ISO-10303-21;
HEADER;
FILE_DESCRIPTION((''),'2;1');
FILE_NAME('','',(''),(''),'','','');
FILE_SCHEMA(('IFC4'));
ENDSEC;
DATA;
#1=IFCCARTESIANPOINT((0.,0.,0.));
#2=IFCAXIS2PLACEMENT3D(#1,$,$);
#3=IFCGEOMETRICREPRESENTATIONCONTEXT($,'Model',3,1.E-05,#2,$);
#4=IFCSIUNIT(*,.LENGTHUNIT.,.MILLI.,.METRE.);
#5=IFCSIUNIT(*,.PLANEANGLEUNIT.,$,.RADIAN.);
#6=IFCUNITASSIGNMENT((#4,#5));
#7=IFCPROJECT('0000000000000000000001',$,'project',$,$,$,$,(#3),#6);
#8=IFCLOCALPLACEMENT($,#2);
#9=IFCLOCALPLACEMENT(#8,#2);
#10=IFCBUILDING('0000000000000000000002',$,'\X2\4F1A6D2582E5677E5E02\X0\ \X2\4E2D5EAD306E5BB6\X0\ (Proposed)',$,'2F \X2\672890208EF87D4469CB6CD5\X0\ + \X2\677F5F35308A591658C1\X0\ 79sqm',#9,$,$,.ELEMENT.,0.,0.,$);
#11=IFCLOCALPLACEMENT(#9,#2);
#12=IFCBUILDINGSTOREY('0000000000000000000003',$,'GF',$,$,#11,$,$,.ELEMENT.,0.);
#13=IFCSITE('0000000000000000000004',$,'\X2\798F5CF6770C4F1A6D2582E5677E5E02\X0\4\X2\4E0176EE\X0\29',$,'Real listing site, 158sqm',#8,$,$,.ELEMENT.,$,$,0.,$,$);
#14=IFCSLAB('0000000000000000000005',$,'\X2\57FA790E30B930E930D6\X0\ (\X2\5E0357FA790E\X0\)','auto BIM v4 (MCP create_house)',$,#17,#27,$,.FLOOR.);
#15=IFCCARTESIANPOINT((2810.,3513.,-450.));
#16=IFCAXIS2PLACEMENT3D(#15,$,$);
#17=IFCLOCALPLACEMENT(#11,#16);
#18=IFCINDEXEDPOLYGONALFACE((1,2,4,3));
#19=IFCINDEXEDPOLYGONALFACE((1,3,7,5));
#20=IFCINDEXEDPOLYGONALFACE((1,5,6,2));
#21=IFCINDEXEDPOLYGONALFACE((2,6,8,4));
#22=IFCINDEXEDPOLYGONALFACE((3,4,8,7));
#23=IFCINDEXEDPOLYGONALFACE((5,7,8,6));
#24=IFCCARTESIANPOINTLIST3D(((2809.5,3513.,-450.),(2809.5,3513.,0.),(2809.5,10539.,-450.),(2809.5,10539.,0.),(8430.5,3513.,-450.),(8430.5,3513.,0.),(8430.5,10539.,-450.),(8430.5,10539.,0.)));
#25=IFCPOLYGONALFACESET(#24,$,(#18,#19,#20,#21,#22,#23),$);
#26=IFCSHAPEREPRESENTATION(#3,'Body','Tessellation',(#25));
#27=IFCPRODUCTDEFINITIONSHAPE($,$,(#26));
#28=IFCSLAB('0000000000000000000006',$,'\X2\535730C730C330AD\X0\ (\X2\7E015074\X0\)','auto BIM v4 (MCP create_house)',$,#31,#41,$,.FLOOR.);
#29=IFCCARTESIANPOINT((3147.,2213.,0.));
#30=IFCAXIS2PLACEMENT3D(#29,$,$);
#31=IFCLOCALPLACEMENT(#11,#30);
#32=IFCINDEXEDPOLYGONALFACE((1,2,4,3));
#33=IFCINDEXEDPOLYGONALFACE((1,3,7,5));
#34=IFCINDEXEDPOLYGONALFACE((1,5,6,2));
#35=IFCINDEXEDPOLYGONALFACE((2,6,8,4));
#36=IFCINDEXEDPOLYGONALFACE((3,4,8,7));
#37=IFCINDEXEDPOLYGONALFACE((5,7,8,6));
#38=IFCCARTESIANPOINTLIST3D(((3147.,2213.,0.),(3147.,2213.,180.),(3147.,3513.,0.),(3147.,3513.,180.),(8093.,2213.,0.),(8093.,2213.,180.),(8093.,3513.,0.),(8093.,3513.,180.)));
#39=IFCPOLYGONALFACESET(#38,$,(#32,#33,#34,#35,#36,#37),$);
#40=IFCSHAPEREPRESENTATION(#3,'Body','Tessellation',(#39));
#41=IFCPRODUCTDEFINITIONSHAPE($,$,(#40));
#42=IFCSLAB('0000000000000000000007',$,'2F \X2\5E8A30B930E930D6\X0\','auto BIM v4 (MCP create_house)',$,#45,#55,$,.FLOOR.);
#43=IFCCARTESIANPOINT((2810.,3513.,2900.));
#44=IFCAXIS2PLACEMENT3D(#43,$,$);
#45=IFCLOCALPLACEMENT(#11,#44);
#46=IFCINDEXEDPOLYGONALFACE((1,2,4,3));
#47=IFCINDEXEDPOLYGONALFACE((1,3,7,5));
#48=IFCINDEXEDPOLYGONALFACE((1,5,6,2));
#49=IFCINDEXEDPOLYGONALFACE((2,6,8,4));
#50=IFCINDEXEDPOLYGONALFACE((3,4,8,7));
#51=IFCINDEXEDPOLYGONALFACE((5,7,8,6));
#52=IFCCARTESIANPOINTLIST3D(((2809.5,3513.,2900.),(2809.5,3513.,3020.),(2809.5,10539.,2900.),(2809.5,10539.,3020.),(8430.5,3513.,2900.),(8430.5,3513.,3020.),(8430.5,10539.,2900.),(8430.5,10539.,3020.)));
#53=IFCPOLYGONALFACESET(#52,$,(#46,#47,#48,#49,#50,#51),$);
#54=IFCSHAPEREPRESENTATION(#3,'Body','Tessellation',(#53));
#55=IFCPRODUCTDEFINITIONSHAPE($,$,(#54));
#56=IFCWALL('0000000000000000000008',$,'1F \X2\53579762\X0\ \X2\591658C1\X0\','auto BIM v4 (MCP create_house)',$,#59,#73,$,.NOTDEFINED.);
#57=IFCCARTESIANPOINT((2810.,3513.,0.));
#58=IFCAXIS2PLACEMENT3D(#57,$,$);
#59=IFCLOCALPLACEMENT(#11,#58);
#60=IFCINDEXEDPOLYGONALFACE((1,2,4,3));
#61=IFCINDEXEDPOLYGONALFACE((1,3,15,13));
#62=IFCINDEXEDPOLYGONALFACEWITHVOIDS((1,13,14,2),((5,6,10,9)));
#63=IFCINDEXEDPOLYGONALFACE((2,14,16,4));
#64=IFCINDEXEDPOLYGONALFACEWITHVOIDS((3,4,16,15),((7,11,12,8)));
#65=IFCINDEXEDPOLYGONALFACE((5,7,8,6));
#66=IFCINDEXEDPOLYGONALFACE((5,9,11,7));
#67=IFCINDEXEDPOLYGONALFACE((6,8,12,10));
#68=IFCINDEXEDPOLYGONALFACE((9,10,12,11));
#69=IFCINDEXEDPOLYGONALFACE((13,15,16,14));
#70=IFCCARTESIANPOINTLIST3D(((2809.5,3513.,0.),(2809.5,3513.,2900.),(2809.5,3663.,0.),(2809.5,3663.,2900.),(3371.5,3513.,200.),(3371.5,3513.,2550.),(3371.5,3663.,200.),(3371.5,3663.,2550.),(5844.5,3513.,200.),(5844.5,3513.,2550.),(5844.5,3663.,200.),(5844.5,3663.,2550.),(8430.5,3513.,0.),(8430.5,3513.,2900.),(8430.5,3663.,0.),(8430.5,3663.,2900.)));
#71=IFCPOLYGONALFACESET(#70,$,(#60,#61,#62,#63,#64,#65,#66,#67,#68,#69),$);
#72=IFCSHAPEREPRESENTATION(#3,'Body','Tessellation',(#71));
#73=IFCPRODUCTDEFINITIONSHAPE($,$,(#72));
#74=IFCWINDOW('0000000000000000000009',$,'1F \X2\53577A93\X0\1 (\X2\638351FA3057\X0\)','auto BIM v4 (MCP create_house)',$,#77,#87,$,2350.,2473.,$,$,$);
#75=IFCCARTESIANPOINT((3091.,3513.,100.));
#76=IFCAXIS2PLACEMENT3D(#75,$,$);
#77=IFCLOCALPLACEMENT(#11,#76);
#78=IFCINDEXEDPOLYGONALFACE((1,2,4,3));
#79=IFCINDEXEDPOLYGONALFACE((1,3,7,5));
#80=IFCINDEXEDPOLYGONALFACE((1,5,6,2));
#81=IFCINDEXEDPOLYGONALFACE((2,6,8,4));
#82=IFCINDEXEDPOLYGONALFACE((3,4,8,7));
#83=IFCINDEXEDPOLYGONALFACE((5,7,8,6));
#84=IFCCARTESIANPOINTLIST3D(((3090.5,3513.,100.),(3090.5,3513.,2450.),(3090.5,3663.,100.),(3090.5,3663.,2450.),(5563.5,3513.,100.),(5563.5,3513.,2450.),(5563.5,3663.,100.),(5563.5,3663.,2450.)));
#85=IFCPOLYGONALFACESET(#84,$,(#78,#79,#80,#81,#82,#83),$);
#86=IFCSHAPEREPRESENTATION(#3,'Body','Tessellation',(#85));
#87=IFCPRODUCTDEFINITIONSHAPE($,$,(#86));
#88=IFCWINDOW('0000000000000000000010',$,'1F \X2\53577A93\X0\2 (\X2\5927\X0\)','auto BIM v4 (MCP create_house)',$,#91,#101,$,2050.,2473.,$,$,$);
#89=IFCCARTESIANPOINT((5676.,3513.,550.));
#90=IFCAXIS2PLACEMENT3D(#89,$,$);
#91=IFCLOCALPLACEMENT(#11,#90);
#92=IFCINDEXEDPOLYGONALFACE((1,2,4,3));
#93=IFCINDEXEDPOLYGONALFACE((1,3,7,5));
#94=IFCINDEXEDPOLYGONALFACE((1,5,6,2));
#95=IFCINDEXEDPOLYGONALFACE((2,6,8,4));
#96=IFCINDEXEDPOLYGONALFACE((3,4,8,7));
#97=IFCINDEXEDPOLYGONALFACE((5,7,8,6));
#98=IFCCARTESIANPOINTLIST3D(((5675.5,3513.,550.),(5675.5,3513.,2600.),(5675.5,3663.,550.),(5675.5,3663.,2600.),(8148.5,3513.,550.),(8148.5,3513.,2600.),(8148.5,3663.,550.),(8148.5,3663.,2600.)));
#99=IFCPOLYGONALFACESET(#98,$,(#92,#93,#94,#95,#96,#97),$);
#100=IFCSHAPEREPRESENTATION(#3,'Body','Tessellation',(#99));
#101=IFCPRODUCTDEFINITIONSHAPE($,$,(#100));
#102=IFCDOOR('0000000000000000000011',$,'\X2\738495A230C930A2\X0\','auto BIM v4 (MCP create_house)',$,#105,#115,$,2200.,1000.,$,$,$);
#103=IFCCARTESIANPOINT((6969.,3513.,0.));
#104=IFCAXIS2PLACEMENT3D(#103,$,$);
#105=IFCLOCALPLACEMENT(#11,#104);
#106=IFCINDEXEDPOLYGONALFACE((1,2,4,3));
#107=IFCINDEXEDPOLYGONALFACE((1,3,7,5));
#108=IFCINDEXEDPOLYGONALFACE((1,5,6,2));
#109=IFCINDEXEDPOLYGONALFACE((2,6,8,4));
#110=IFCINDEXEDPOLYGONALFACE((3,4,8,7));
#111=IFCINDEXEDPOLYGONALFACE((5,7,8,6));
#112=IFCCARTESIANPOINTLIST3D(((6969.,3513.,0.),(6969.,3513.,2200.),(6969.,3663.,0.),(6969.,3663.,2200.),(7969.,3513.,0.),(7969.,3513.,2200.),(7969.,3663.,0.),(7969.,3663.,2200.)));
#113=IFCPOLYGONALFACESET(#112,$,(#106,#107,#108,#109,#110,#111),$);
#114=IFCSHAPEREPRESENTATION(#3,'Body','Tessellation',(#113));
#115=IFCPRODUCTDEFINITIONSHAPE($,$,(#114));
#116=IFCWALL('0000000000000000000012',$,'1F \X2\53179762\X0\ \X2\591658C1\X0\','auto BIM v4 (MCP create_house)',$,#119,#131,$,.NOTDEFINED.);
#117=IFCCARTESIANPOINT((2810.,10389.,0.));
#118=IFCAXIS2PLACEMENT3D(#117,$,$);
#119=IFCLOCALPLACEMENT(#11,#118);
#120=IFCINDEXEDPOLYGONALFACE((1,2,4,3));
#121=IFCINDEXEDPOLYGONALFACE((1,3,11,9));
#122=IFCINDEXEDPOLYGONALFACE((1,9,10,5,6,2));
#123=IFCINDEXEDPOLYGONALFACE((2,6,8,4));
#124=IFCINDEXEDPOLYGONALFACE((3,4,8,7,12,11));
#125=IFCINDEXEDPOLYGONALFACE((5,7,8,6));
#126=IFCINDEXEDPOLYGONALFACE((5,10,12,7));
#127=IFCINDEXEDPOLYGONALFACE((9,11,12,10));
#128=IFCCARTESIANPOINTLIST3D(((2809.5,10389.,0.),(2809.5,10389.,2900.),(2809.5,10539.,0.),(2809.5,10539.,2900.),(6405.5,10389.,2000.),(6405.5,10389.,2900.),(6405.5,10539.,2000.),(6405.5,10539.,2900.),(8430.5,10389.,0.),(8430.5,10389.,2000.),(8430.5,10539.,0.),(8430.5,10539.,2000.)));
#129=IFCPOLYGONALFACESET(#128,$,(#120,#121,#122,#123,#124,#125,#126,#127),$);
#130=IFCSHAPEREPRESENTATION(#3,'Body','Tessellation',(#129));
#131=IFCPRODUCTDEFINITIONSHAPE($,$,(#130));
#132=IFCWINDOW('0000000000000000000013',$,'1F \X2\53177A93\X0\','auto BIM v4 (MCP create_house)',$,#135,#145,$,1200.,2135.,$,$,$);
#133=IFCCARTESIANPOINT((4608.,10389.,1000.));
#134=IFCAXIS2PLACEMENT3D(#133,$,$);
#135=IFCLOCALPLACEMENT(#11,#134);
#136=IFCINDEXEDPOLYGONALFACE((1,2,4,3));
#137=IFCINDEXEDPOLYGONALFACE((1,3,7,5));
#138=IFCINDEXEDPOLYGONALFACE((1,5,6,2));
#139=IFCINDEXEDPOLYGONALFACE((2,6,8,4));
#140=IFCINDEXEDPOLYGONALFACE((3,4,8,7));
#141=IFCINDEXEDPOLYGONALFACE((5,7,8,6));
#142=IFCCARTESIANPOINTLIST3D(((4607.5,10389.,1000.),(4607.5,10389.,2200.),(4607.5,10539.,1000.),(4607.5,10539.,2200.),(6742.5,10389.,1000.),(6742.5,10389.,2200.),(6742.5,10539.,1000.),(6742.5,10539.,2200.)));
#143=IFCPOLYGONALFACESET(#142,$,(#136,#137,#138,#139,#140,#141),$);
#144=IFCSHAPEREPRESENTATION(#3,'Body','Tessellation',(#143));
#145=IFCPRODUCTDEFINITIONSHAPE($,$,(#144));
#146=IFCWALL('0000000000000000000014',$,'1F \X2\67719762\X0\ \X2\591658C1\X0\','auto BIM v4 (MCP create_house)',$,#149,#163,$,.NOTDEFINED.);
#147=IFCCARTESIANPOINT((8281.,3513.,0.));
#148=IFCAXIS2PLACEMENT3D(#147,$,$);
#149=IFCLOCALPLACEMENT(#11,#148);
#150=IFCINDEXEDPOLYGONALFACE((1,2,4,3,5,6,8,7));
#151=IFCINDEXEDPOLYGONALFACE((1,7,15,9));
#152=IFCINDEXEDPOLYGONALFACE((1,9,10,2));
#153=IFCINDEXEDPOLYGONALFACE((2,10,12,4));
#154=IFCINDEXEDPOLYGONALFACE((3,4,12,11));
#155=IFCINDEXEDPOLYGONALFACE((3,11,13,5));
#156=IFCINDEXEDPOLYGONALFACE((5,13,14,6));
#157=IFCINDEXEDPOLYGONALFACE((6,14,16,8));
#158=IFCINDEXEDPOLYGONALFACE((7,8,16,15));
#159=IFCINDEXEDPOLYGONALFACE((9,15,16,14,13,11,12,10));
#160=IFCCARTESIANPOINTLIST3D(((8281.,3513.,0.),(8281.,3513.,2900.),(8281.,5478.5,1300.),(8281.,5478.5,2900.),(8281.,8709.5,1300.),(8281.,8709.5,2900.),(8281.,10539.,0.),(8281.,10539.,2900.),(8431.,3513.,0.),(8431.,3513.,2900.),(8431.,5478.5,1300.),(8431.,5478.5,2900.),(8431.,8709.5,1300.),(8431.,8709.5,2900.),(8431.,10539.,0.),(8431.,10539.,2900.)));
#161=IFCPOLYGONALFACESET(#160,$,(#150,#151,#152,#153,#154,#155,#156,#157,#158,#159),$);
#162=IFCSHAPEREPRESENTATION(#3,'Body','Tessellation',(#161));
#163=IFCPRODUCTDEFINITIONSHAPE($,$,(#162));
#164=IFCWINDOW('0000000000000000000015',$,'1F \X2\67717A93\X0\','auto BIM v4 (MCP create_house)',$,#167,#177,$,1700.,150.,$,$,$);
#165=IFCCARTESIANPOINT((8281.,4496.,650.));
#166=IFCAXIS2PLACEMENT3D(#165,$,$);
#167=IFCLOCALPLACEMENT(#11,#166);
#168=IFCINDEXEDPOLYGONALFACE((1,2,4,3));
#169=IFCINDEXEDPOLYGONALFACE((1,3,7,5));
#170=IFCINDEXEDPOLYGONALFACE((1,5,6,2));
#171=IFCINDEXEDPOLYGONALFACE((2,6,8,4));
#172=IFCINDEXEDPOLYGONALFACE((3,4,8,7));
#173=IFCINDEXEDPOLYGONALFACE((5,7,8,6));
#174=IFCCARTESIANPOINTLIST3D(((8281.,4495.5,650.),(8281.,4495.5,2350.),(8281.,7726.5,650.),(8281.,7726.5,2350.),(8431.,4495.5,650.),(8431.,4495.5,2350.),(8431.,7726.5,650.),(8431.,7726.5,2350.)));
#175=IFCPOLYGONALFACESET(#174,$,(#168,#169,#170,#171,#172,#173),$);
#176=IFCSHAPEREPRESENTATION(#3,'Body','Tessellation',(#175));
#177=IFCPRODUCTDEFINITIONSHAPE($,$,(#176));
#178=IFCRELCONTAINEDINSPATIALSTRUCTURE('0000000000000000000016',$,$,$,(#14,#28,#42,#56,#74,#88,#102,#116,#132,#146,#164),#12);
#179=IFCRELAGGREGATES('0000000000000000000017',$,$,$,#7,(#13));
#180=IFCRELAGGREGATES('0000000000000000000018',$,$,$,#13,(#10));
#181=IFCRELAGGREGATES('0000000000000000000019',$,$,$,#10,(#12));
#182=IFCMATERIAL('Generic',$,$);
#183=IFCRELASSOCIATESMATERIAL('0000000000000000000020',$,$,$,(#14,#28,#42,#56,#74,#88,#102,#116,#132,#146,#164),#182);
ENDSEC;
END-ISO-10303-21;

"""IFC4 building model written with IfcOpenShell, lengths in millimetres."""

from ifc_helpers import new_model, si_unit, frame, frame_2d, origin, place, context, project, spatial, rectangle, extrude, material, element, fill, save


model = new_model("IFC4")

# Units and contexts
model_context = context("Model", 3, precision=1e-05, world=origin())
ifc_project = project(units=[si_unit("LENGTHUNIT", "METRE", prefix="MILLI"), si_unit("PLANEANGLEUNIT", "RADIAN")], contexts=[model_context])

# Site, building, storey
site_placement = place(None, origin())
site = spatial("IfcSite", under=ifc_project, at=site_placement, Name="福島県会津若松市4丁目29", ObjectType="Real listing site, 158sqm", CompositionType="ELEMENT", RefElevation=0.0)
building_placement = place(site_placement, origin())
building = spatial("IfcBuilding", under=site, at=building_placement, Name="会津若松市 中庭の家 (Proposed)", ObjectType="2F 木造軸組構法 + 板張り外壁 79sqm", CompositionType="ELEMENT", ElevationOfRefHeight=0.0, ElevationOfTerrain=0.0)
storey_placement = place(building_placement, origin())
storey = spatial("IfcBuildingStorey", under=building, at=storey_placement, Name="GF", CompositionType="ELEMENT", Elevation=0.0)

# Slabs
ifc_material = material(Name="Generic")
slab_1_placement = place(storey_placement, frame((2810.0, 3513.0, -450.0)))
element("IfcSlab", 1, at=slab_1_placement, inside=storey, material=ifc_material, Name="基礎スラブ (布基礎)", Description="auto BIM v4 (MCP create_house)", PredefinedType="FLOOR", context=model_context, shape_type="SweptSolid", body=[
    extrude(rectangle(XDim=5621.0, YDim=7026.0, at=frame_2d((2810.0, 3513.0))), frame((2810.0, 3513.0, -450.0)), (0.0, 0.0, 1.0), 450.0),
])
slab_2_placement = place(storey_placement, frame((3147.0, 2213.0, 0.0)))
element("IfcSlab", 2, at=slab_2_placement, inside=storey, material=ifc_material, Name="南デッキ (縁側)", Description="auto BIM v4 (MCP create_house)", PredefinedType="FLOOR", context=model_context, shape_type="SweptSolid", body=[
    extrude(rectangle(XDim=4946.0, YDim=1300.0, at=frame_2d((2473.0, 650.0))), frame((3147.0, 2213.0, 0.0)), (0.0, 0.0, 1.0), 180.0),
])
slab_3_placement = place(storey_placement, frame((2810.0, 3513.0, 2900.0)))
element("IfcSlab", 3, at=slab_3_placement, inside=storey, material=ifc_material, Name="2F 床スラブ", Description="auto BIM v4 (MCP create_house)", PredefinedType="FLOOR", context=model_context, shape_type="SweptSolid", body=[
    extrude(rectangle(XDim=5621.0, YDim=7026.0, at=frame_2d((2810.0, 3513.0))), frame((2810.0, 3513.0, 2900.0)), (0.0, 0.0, 1.0), 120.0),
])

# Wall, openings, windows, door
wall_1_placement = place(storey_placement, frame((2810.0, 3513.0, 0.0)))
wall_1 = element("IfcWall", 4, at=wall_1_placement, inside=storey, material=ifc_material, Name="1F 南面 外壁", Description="auto BIM v4 (MCP create_house)", PredefinedType="NOTDEFINED", context=model_context, shape_type="SweptSolid", body=[
    extrude(rectangle(XDim=5621.0, YDim=150.0, at=frame_2d((2810.0, 75.0))), frame((2810.0, 3513.0, 0.0)), (0.0, 0.0, 1.0), 2900.0),
])
opening_1_placement = place(storey_placement, frame((3091.0, 3513.0, 100.0)))
opening_1 = element("IfcOpeningElement", 5, at=opening_1_placement, cuts=wall_1, PredefinedType="NOTDEFINED", context=model_context, shape_type="SweptSolid", body=[
    extrude(rectangle(XDim=2473.0, YDim=150.0, at=frame_2d((1236.0, 75.0))), frame((3091.0, 3513.0, 100.0)), (0.0, 0.0, 1.0), 2350.0),
])
opening_2_placement = place(storey_placement, frame((5676.0, 3513.0, 550.0)))
opening_2 = element("IfcOpeningElement", 6, at=opening_2_placement, cuts=wall_1, PredefinedType="NOTDEFINED", context=model_context, shape_type="SweptSolid", body=[
    extrude(rectangle(XDim=2473.0, YDim=150.0, at=frame_2d((1236.0, 75.0))), frame((5676.0, 3513.0, 550.0)), (0.0, 0.0, 1.0), 2050.0),
])
opening_3_placement = place(storey_placement, frame((6969.0, 3513.0, 0.0)))
opening_3 = element("IfcOpeningElement", 7, at=opening_3_placement, cuts=wall_1, PredefinedType="NOTDEFINED", context=model_context, shape_type="SweptSolid", body=[
    extrude(rectangle(XDim=1000.0, YDim=150.0, at=frame_2d((500.0, 75.0))), frame((6969.0, 3513.0, 0.0)), (0.0, 0.0, 1.0), 2200.0),
])
window_1_placement = place(storey_placement, frame((3091.0, 3513.0, 100.0)))
window_1 = element("IfcWindow", 8, at=window_1_placement, inside=storey, material=ifc_material, Name="1F 南窓1 (掃出し)", Description="auto BIM v4 (MCP create_house)", OverallHeight=2350.0, OverallWidth=2473.0, context=model_context, shape_type="SweptSolid", body=[
    extrude(rectangle(XDim=2473.0, YDim=150.0, at=frame_2d((1236.0, 75.0))), frame((3091.0, 3513.0, 100.0)), (0.0, 0.0, 1.0), 2350.0),
])
fill(opening_1, window_1)
window_2_placement = place(storey_placement, frame((5676.0, 3513.0, 550.0)))
window_2 = element("IfcWindow", 9, at=window_2_placement, inside=storey, material=ifc_material, Name="1F 南窓2 (大)", Description="auto BIM v4 (MCP create_house)", OverallHeight=2050.0, OverallWidth=2473.0, context=model_context, shape_type="SweptSolid", body=[
    extrude(rectangle(XDim=2473.0, YDim=150.0, at=frame_2d((1236.0, 75.0))), frame((5676.0, 3513.0, 550.0)), (0.0, 0.0, 1.0), 2050.0),
])
fill(opening_2, window_2)
door_1_placement = place(storey_placement, frame((6969.0, 3513.0, 0.0)))
door_1 = element("IfcDoor", 10, at=door_1_placement, inside=storey, material=ifc_material, Name="玄関ドア", Description="auto BIM v4 (MCP create_house)", OverallHeight=2200.0, OverallWidth=1000.0, context=model_context, shape_type="SweptSolid", body=[
    extrude(rectangle(XDim=1000.0, YDim=150.0, at=frame_2d((500.0, 75.0))), frame((6969.0, 3513.0, 0.0)), (0.0, 0.0, 1.0), 2200.0),
])
fill(opening_3, door_1)

# Walls, openings, windows
wall_2_placement = place(storey_placement, frame((2810.0, 10389.0, 0.0)))
wall_2 = element("IfcWall", 11, at=wall_2_placement, inside=storey, material=ifc_material, Name="1F 北面 外壁", Description="auto BIM v4 (MCP create_house)", PredefinedType="NOTDEFINED", context=model_context, shape_type="SweptSolid", body=[
    extrude(rectangle(XDim=5621.0, YDim=150.0, at=frame_2d((2810.0, 75.0))), frame((2810.0, 10389.0, 0.0)), (0.0, 0.0, 1.0), 2900.0),
])
opening_4_placement = place(storey_placement, frame((4608.0, 10389.0, 1000.0)))
opening_4 = element("IfcOpeningElement", 12, at=opening_4_placement, cuts=wall_2, PredefinedType="NOTDEFINED", context=model_context, shape_type="SweptSolid", body=[
    extrude(rectangle(XDim=2135.0, YDim=150.0, at=frame_2d((1067.0, 75.0))), frame((4608.0, 10389.0, 1000.0)), (0.0, 0.0, 1.0), 1200.0),
])
window_3_placement = place(storey_placement, frame((4608.0, 10389.0, 1000.0)))
window_3 = element("IfcWindow", 13, at=window_3_placement, inside=storey, material=ifc_material, Name="1F 北窓", Description="auto BIM v4 (MCP create_house)", OverallHeight=1200.0, OverallWidth=2135.0, context=model_context, shape_type="SweptSolid", body=[
    extrude(rectangle(XDim=2135.0, YDim=150.0, at=frame_2d((1067.0, 75.0))), frame((4608.0, 10389.0, 1000.0)), (0.0, 0.0, 1.0), 1200.0),
])
fill(opening_4, window_3)
wall_3_placement = place(storey_placement, frame((8281.0, 3513.0, 0.0)))
wall_3 = element("IfcWall", 14, at=wall_3_placement, inside=storey, material=ifc_material, Name="1F 東面 外壁", Description="auto BIM v4 (MCP create_house)", PredefinedType="NOTDEFINED", context=model_context, shape_type="SweptSolid", body=[
    extrude(rectangle(XDim=150.0, YDim=7026.0, at=frame_2d((75.0, 3513.0))), frame((8281.0, 3513.0, 0.0)), (0.0, 0.0, 1.0), 2900.0),
])
opening_5_placement = place(storey_placement, frame((8281.0, 4496.0, 650.0)))
opening_5 = element("IfcOpeningElement", 15, at=opening_5_placement, cuts=wall_3, PredefinedType="NOTDEFINED", context=model_context, shape_type="SweptSolid", body=[
    extrude(rectangle(XDim=150.0, YDim=3231.0, at=frame_2d((75.0, 1615.0))), frame((8281.0, 4496.0, 650.0)), (0.0, 0.0, 1.0), 1700.0),
])
window_4_placement = place(storey_placement, frame((8281.0, 4496.0, 650.0)))
window_4 = element("IfcWindow", 16, at=window_4_placement, inside=storey, material=ifc_material, Name="1F 東窓", Description="auto BIM v4 (MCP create_house)", OverallHeight=1700.0, OverallWidth=150.0, context=model_context, shape_type="SweptSolid", body=[
    extrude(rectangle(XDim=150.0, YDim=3231.0, at=frame_2d((75.0, 1615.0))), frame((8281.0, 4496.0, 650.0)), (0.0, 0.0, 1.0), 1700.0),
])
fill(opening_5, window_4)

save(model, "model.ifc")
